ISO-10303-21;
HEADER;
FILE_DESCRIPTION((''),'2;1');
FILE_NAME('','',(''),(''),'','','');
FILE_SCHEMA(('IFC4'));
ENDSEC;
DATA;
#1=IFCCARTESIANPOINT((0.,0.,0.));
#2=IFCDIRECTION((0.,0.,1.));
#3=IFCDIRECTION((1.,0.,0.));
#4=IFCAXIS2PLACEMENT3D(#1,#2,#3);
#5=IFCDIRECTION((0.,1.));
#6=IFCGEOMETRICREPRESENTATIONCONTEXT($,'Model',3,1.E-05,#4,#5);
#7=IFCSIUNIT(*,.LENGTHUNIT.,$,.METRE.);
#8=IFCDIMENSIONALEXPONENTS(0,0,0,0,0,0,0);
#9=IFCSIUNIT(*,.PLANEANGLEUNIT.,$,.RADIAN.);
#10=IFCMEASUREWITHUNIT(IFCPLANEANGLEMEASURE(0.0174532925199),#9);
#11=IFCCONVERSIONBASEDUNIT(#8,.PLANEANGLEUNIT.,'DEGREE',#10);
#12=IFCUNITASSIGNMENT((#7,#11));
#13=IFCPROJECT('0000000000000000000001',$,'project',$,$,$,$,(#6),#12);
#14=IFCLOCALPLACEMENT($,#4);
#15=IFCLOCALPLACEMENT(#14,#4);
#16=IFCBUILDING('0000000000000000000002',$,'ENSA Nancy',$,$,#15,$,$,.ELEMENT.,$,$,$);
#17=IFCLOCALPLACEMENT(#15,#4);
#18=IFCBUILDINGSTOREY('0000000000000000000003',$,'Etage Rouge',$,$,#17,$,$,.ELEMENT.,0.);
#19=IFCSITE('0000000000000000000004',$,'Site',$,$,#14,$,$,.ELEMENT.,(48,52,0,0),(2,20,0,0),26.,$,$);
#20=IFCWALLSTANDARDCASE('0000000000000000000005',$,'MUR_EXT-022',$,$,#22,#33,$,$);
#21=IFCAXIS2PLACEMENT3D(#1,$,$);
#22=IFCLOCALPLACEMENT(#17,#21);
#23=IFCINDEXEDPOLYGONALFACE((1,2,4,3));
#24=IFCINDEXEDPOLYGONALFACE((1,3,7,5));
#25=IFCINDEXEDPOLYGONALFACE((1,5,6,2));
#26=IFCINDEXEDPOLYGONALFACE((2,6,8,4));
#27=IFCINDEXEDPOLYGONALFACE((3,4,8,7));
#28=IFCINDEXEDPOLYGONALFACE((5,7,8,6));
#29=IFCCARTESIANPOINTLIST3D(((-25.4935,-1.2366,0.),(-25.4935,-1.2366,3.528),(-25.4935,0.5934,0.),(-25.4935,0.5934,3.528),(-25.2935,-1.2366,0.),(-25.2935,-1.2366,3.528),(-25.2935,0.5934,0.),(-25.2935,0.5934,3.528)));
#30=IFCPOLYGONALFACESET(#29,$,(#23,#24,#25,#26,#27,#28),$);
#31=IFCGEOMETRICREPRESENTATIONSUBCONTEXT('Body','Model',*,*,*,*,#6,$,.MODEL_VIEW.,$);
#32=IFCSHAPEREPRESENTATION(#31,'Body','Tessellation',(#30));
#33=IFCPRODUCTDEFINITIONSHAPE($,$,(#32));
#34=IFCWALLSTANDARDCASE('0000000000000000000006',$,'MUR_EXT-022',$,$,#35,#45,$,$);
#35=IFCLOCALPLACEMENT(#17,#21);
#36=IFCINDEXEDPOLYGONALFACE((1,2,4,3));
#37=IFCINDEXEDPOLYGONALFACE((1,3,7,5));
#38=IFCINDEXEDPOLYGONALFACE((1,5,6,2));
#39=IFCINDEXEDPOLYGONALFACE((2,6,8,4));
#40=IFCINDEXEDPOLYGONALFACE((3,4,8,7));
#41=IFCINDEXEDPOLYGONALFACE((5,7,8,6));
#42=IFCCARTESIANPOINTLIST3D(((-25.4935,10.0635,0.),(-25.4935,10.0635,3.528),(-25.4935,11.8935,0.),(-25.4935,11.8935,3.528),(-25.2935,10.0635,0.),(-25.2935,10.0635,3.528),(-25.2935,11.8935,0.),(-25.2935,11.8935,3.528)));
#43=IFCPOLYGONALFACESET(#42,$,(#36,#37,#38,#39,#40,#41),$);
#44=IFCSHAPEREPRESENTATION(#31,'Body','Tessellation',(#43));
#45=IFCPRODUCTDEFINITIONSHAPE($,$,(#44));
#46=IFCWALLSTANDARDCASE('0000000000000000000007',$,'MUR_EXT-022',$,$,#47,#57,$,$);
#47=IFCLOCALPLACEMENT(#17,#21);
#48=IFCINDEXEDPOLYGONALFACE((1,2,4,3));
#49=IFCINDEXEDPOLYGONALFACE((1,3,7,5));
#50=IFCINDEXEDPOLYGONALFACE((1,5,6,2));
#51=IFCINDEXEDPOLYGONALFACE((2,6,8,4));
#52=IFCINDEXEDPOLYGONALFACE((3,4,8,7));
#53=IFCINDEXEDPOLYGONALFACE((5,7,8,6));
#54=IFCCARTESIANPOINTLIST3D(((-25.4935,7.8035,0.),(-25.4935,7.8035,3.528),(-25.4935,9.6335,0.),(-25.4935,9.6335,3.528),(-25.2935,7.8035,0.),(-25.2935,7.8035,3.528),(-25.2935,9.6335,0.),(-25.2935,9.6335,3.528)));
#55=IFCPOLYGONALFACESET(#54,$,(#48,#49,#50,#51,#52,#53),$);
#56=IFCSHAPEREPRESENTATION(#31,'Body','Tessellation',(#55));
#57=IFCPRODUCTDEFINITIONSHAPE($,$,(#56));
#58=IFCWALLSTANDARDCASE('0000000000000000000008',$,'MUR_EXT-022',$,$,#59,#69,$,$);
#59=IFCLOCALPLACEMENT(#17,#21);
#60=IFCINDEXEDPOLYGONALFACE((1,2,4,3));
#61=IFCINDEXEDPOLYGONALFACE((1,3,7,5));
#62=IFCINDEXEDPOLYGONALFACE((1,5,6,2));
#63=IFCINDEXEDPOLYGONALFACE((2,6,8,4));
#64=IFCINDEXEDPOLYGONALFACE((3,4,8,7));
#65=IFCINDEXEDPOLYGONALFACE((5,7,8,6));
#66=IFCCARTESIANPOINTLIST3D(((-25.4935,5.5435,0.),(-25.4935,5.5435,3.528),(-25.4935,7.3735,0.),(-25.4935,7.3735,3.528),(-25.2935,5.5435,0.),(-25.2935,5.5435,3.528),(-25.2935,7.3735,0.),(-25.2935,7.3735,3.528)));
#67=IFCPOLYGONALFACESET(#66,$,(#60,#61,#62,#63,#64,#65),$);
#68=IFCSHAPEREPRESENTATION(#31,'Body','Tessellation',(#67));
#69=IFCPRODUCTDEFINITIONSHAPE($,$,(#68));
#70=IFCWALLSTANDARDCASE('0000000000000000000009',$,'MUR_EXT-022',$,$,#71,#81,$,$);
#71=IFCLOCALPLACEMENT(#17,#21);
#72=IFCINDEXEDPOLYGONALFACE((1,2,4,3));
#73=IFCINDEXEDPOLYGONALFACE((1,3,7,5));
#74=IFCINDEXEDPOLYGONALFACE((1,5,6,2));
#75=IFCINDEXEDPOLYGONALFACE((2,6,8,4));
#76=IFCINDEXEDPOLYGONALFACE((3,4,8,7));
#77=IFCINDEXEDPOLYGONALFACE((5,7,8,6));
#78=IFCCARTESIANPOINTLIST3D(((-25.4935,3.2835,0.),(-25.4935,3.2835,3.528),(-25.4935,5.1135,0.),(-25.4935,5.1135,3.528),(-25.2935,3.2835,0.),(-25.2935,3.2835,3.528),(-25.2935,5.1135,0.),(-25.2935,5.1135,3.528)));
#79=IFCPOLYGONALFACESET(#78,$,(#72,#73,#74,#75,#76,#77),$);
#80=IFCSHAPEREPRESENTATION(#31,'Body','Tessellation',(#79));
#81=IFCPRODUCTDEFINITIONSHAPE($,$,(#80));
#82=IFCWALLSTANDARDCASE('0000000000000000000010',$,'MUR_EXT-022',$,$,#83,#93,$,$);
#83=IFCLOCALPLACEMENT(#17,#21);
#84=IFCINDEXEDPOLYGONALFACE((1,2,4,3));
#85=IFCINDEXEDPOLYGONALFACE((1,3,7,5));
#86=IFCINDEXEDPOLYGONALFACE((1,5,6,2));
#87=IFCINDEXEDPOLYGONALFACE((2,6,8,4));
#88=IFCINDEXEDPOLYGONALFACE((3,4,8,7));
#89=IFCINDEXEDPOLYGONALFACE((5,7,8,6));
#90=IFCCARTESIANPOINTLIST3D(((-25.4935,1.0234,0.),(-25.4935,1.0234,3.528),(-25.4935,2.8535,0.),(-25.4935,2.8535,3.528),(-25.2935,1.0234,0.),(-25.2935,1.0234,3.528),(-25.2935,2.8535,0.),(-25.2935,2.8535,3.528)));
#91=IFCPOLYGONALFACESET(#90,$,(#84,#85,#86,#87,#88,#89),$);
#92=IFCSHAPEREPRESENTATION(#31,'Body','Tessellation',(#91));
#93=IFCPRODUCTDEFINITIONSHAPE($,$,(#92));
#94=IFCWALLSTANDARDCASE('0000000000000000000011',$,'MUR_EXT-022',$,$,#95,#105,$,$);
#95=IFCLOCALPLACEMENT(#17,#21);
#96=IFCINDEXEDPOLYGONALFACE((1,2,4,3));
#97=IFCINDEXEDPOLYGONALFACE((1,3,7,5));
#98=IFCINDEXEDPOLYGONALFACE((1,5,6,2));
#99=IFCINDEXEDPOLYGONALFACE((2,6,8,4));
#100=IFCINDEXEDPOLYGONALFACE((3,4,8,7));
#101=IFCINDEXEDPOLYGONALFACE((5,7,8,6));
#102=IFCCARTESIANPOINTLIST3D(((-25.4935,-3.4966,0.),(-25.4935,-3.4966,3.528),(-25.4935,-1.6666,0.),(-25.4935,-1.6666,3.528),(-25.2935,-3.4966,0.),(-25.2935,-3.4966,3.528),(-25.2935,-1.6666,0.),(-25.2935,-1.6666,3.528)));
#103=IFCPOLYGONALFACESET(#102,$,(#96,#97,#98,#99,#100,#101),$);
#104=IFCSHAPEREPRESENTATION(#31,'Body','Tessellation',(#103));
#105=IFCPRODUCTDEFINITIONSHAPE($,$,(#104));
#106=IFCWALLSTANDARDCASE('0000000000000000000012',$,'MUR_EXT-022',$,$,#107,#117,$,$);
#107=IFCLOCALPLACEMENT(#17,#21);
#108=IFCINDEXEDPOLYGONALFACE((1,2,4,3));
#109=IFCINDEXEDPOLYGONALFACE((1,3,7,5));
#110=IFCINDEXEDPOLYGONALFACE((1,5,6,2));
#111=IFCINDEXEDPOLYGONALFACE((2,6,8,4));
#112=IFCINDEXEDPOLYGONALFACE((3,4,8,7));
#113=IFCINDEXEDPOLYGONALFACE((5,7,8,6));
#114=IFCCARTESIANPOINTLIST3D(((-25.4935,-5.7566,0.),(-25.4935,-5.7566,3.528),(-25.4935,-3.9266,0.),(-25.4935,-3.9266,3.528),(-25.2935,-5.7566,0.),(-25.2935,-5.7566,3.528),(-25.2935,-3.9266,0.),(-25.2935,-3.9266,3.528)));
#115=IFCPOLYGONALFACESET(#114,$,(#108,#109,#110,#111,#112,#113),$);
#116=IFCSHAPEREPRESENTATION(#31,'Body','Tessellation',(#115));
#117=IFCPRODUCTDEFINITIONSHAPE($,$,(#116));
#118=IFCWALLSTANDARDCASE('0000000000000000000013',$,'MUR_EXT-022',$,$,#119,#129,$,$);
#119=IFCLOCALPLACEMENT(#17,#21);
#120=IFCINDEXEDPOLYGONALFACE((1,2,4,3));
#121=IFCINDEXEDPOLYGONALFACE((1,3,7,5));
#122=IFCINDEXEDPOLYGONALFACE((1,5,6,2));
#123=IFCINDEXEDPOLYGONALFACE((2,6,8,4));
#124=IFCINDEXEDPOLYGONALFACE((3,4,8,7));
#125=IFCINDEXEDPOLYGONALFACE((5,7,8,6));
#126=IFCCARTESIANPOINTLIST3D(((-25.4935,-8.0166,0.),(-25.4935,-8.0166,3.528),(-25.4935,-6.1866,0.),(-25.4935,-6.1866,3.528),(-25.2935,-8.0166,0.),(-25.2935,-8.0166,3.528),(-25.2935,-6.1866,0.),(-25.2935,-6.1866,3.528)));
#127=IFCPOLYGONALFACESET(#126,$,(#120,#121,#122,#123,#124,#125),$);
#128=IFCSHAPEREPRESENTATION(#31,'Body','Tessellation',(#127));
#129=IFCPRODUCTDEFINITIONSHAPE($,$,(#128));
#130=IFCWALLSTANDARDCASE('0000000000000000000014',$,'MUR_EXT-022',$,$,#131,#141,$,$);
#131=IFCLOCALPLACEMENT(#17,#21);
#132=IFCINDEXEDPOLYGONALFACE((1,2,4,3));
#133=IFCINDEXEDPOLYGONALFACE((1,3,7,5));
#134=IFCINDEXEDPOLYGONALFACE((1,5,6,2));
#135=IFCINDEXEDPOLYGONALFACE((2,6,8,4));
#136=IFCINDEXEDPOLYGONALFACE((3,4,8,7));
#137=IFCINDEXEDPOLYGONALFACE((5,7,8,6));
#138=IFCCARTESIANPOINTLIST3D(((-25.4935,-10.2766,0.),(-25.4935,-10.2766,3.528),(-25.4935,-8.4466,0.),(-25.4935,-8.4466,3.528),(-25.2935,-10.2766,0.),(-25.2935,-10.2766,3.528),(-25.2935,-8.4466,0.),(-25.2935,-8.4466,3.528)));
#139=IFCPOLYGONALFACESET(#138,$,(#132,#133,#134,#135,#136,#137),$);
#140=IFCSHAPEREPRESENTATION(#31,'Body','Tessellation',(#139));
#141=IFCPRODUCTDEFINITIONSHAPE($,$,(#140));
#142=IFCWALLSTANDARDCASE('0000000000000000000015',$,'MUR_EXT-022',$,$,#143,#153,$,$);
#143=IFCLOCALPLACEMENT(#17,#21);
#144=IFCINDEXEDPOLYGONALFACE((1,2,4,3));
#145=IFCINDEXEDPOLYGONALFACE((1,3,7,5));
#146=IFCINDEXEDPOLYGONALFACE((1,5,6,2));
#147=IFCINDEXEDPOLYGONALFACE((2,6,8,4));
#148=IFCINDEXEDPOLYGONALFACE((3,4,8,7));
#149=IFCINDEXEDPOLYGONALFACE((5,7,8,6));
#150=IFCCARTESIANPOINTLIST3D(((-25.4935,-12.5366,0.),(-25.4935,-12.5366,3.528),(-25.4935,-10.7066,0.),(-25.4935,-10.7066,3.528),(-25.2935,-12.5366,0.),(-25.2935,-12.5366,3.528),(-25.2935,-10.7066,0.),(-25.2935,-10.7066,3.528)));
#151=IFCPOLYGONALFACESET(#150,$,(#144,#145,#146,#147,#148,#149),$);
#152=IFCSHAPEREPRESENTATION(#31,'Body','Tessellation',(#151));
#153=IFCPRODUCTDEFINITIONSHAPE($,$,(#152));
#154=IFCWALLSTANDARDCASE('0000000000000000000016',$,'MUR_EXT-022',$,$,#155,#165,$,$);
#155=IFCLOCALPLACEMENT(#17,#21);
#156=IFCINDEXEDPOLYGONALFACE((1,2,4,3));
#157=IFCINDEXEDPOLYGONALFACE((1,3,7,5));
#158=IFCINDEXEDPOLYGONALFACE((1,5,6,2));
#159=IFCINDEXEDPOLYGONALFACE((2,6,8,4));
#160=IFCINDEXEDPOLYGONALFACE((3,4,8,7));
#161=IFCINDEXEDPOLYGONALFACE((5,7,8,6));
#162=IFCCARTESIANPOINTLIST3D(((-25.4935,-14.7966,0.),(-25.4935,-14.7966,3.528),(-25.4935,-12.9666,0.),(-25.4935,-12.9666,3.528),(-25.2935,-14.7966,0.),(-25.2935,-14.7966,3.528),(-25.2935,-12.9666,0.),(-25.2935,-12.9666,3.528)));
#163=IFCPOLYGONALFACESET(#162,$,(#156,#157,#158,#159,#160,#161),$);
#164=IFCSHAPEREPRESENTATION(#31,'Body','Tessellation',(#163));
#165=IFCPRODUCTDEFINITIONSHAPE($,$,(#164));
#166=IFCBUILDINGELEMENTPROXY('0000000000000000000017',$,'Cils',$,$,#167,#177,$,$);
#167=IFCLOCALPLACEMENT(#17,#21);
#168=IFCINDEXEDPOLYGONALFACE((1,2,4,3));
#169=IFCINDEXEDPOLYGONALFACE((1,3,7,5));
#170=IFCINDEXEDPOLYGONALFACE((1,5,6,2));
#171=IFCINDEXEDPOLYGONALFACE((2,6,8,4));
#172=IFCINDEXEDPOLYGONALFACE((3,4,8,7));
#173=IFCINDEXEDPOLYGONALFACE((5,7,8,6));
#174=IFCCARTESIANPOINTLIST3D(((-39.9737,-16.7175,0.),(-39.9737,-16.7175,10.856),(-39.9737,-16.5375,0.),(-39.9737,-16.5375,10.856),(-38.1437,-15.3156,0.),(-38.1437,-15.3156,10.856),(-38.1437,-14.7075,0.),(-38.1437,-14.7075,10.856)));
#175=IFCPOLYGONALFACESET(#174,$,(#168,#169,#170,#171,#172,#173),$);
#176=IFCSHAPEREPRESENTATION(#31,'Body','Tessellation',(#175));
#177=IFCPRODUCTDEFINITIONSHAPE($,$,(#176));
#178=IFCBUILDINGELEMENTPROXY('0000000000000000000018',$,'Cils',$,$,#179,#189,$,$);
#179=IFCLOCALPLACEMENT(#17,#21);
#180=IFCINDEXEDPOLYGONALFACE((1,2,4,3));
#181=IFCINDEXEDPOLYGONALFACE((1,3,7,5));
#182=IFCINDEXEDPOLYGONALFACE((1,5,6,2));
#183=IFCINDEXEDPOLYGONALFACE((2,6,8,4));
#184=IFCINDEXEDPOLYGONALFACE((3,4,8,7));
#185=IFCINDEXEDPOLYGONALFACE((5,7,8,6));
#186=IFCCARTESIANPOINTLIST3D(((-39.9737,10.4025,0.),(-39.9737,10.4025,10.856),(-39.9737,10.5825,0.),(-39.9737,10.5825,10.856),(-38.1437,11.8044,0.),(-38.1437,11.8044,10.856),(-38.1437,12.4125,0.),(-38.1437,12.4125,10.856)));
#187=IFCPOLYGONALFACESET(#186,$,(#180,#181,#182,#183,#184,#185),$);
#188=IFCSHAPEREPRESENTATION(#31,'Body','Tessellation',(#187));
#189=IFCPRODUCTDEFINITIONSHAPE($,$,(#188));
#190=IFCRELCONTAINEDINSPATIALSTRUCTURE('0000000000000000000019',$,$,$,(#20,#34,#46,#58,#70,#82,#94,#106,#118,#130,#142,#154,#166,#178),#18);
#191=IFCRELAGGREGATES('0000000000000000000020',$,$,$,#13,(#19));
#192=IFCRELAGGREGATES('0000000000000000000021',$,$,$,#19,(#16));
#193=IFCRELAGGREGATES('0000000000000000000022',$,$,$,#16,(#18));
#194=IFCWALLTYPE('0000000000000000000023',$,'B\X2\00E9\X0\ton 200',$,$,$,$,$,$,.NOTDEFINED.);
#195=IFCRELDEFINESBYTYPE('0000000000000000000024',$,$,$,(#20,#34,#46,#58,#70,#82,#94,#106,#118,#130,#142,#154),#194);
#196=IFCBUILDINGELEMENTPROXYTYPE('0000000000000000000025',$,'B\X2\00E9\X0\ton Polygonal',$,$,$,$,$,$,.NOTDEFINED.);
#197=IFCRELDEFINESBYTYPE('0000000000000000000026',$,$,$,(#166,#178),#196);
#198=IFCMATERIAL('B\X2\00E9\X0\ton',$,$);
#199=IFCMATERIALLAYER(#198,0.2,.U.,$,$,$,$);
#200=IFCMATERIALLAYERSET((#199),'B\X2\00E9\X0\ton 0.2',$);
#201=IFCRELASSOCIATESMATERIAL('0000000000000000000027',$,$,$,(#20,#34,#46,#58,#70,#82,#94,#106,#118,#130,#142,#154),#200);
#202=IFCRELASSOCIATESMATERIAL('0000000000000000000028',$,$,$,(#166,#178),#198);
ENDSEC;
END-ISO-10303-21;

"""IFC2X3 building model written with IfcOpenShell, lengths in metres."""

from ifc_helpers import new_model, entity, si_unit, converted_unit, direction, frame, origin_with_axes, place, context, subcontext, project, spatial, polyline, outline, extrude, material, layer, layer_set, layer_usage, type_object, element, save


model = new_model("IFC2X3")

# Units and contexts
model_context = context("Model", 3, precision=1e-05, world=origin_with_axes(), true_north=direction((0.0, 1.0)))
body_context = subcontext(model_context, "Body", "Model", "MODEL_VIEW")
ifc_project = project(units=[si_unit("LENGTHUNIT", "METRE"), converted_unit("PLANEANGLEUNIT", "DEGREE", entity("IfcPlaneAngleMeasure", 0.0174532925199), si_unit("PLANEANGLEUNIT", "RADIAN"), dimensions=[0, 0, 0, 0, 0, 0, 0])], contexts=[model_context])

# Site, building, storey
site_placement = place(None, origin_with_axes())
site = spatial("IfcSite", under=ifc_project, at=site_placement, Name="Site", CompositionType="ELEMENT", RefLatitude=(48, 52, 0, 0), RefLongitude=(2, 20, 0, 0), RefElevation=26.0)
building_placement = place(site_placement, origin_with_axes())
building = spatial("IfcBuilding", under=site, at=building_placement, Name="ENSA Nancy", CompositionType="ELEMENT")
storey_placement = place(building_placement, origin_with_axes())
storey = spatial("IfcBuildingStorey", under=building, at=storey_placement, Name="Etage Rouge", CompositionType="ELEMENT", Elevation=0.0)

# Walls
ifc_material = material(Name="Béton")
ifc_layer = layer(ifc_material, 0.2, ventilated="UNKNOWN")
ifc_layer_set = layer_set([ifc_layer], Name="Béton 0.2")
ifc_layer_usage_1 = layer_usage(ifc_layer_set, "AXIS2", "POSITIVE", -0.2)
wall_type = type_object("IfcWallType", Name="Béton 200", PredefinedType="NOTDEFINED")
wall_1_placement = place(storey_placement, frame((-25.2935, 0.5934, 0.0), z_axis=(0.0, 0.0, 1.0), x_axis=(0.0, -1.0, 0.0)))
element("IfcWallStandardCase", 1, at=wall_1_placement, inside=storey, type_object=wall_type, material=ifc_layer_usage_1, Name="MUR_EXT-022", context=body_context, shape_type="SweptSolid", body=[
    extrude(outline(polyline([(0.0, -0.2), (1.83, -0.2), (1.83, 0.0), (0.0, 0.0), (0.0, -0.2)])), origin_with_axes(), (0.0, 0.0, 1.0), 3.528),
])
ifc_layer_usage_2 = layer_usage(ifc_layer_set, "AXIS2", "POSITIVE", -0.2)
wall_2_placement = place(storey_placement, frame((-25.2935, 11.8935, 0.0), z_axis=(0.0, 0.0, 1.0), x_axis=(0.0, -1.0, 0.0)))
element("IfcWallStandardCase", 2, at=wall_2_placement, inside=storey, type_object=wall_type, material=ifc_layer_usage_2, Name="MUR_EXT-022", context=body_context, shape_type="SweptSolid", body=[
    extrude(outline(polyline([(0.0, -0.2), (1.83, -0.2), (1.83, 0.0), (0.0, 0.0), (0.0, -0.2)])), origin_with_axes(), (0.0, 0.0, 1.0), 3.528),
])
ifc_layer_usage_3 = layer_usage(ifc_layer_set, "AXIS2", "POSITIVE", -0.2)
wall_3_placement = place(storey_placement, frame((-25.2935, 9.6335, 0.0), z_axis=(0.0, 0.0, 1.0), x_axis=(0.0, -1.0, 0.0)))
element("IfcWallStandardCase", 3, at=wall_3_placement, inside=storey, type_object=wall_type, material=ifc_layer_usage_3, Name="MUR_EXT-022", context=body_context, shape_type="SweptSolid", body=[
    extrude(outline(polyline([(0.0, -0.2), (1.83, -0.2), (1.83, 0.0), (0.0, 0.0), (0.0, -0.2)])), origin_with_axes(), (0.0, 0.0, 1.0), 3.528),
])
ifc_layer_usage_4 = layer_usage(ifc_layer_set, "AXIS2", "POSITIVE", -0.2)
wall_4_placement = place(storey_placement, frame((-25.2935, 7.3735, 0.0), z_axis=(0.0, 0.0, 1.0), x_axis=(0.0, -1.0, 0.0)))
element("IfcWallStandardCase", 4, at=wall_4_placement, inside=storey, type_object=wall_type, material=ifc_layer_usage_4, Name="MUR_EXT-022", context=body_context, shape_type="SweptSolid", body=[
    extrude(outline(polyline([(0.0, -0.2), (1.83, -0.2), (1.83, 0.0), (0.0, 0.0), (0.0, -0.2)])), origin_with_axes(), (0.0, 0.0, 1.0), 3.528),
])
ifc_layer_usage_5 = layer_usage(ifc_layer_set, "AXIS2", "POSITIVE", -0.2)
wall_5_placement = place(storey_placement, frame((-25.2935, 5.1135, 0.0), z_axis=(0.0, 0.0, 1.0), x_axis=(0.0, -1.0, 0.0)))
element("IfcWallStandardCase", 5, at=wall_5_placement, inside=storey, type_object=wall_type, material=ifc_layer_usage_5, Name="MUR_EXT-022", context=body_context, shape_type="SweptSolid", body=[
    extrude(outline(polyline([(0.0, -0.2), (1.83, -0.2), (1.83, 0.0), (0.0, 0.0), (0.0, -0.2)])), origin_with_axes(), (0.0, 0.0, 1.0), 3.528),
])
ifc_layer_usage_6 = layer_usage(ifc_layer_set, "AXIS2", "POSITIVE", -0.2)
wall_6_placement = place(storey_placement, frame((-25.2935, 2.8535, 0.0), z_axis=(0.0, 0.0, 1.0), x_axis=(0.0, -1.0, 0.0)))
element("IfcWallStandardCase", 6, at=wall_6_placement, inside=storey, type_object=wall_type, material=ifc_layer_usage_6, Name="MUR_EXT-022", context=body_context, shape_type="SweptSolid", body=[
    extrude(outline(polyline([(0.0, -0.2), (1.83, -0.2), (1.83, 0.0), (0.0, 0.0), (0.0, -0.2)])), origin_with_axes(), (0.0, 0.0, 1.0), 3.528),
])
ifc_layer_usage_7 = layer_usage(ifc_layer_set, "AXIS2", "POSITIVE", -0.2)
wall_7_placement = place(storey_placement, frame((-25.2935, -1.6666, 0.0), z_axis=(0.0, 0.0, 1.0), x_axis=(0.0, -1.0, 0.0)))
element("IfcWallStandardCase", 7, at=wall_7_placement, inside=storey, type_object=wall_type, material=ifc_layer_usage_7, Name="MUR_EXT-022", context=body_context, shape_type="SweptSolid", body=[
    extrude(outline(polyline([(0.0, -0.2), (1.83, -0.2), (1.83, 0.0), (0.0, 0.0), (0.0, -0.2)])), origin_with_axes(), (0.0, 0.0, 1.0), 3.528),
])
ifc_layer_usage_8 = layer_usage(ifc_layer_set, "AXIS2", "POSITIVE", -0.2)
wall_8_placement = place(storey_placement, frame((-25.2935, -3.9266, 0.0), z_axis=(0.0, 0.0, 1.0), x_axis=(0.0, -1.0, 0.0)))
element("IfcWallStandardCase", 8, at=wall_8_placement, inside=storey, type_object=wall_type, material=ifc_layer_usage_8, Name="MUR_EXT-022", context=body_context, shape_type="SweptSolid", body=[
    extrude(outline(polyline([(0.0, -0.2), (1.83, -0.2), (1.83, 0.0), (0.0, 0.0), (0.0, -0.2)])), origin_with_axes(), (0.0, 0.0, 1.0), 3.528),
])
ifc_layer_usage_9 = layer_usage(ifc_layer_set, "AXIS2", "POSITIVE", -0.2)
wall_9_placement = place(storey_placement, frame((-25.2935, -6.1866, 0.0), z_axis=(0.0, 0.0, 1.0), x_axis=(0.0, -1.0, 0.0)))
element("IfcWallStandardCase", 9, at=wall_9_placement, inside=storey, type_object=wall_type, material=ifc_layer_usage_9, Name="MUR_EXT-022", context=body_context, shape_type="SweptSolid", body=[
    extrude(outline(polyline([(0.0, -0.2), (1.83, -0.2), (1.83, 0.0), (0.0, 0.0), (0.0, -0.2)])), origin_with_axes(), (0.0, 0.0, 1.0), 3.528),
])
ifc_layer_usage_10 = layer_usage(ifc_layer_set, "AXIS2", "POSITIVE", -0.2)
wall_10_placement = place(storey_placement, frame((-25.2935, -8.4466, 0.0), z_axis=(0.0, 0.0, 1.0), x_axis=(0.0, -1.0, 0.0)))
element("IfcWallStandardCase", 10, at=wall_10_placement, inside=storey, type_object=wall_type, material=ifc_layer_usage_10, Name="MUR_EXT-022", context=body_context, shape_type="SweptSolid", body=[
    extrude(outline(polyline([(0.0, -0.2), (1.83, -0.2), (1.83, 0.0), (0.0, 0.0), (0.0, -0.2)])), origin_with_axes(), (0.0, 0.0, 1.0), 3.528),
])
ifc_layer_usage_11 = layer_usage(ifc_layer_set, "AXIS2", "POSITIVE", -0.2)
wall_11_placement = place(storey_placement, frame((-25.2935, -10.7066, 0.0), z_axis=(0.0, 0.0, 1.0), x_axis=(0.0, -1.0, 0.0)))
element("IfcWallStandardCase", 11, at=wall_11_placement, inside=storey, type_object=wall_type, material=ifc_layer_usage_11, Name="MUR_EXT-022", context=body_context, shape_type="SweptSolid", body=[
    extrude(outline(polyline([(0.0, -0.2), (1.83, -0.2), (1.83, 0.0), (0.0, 0.0), (0.0, -0.2)])), origin_with_axes(), (0.0, 0.0, 1.0), 3.528),
])
ifc_layer_usage_12 = layer_usage(ifc_layer_set, "AXIS2", "POSITIVE", -0.2)
wall_12_placement = place(storey_placement, frame((-25.2935, -12.9666, 0.0), z_axis=(0.0, 0.0, 1.0), x_axis=(0.0, -1.0, 0.0)))
element("IfcWallStandardCase", 12, at=wall_12_placement, inside=storey, type_object=wall_type, material=ifc_layer_usage_12, Name="MUR_EXT-022", context=body_context, shape_type="SweptSolid", body=[
    extrude(outline(polyline([(0.0, -0.2), (1.83, -0.2), (1.83, 0.0), (0.0, 0.0), (0.0, -0.2)])), origin_with_axes(), (0.0, 0.0, 1.0), 3.528),
])

# Building element proxies
building_element_proxy_type = type_object("IfcBuildingElementProxyType", Name="Béton Polygonal", PredefinedType="NOTDEFINED")
for number, where, z_axis, x_axis, name in (
    (13, (-38.1437, -14.7075, 0.0), (0.0, 0.0, 1.0), (-0.707107, -0.707107, 0.0), "Cils"),
    (14, (-38.1437, 12.4125, 0.0), (0.0, 0.0, 1.0), (-0.707107, -0.707107, 0.0), "Cils"),
):
    element("IfcBuildingElementProxy", number, at=place(storey_placement, frame(where, z_axis=z_axis, x_axis=x_axis)), inside=storey, type_object=building_element_proxy_type, material=ifc_material, Name=name, context=body_context, shape_type="SweptSolid", body=[
        extrude(outline(polyline([(0.0, 0.0), (2.588, 0.0), (2.7153, 0.1273), (0.43, 0.43), (0.0, 0.0)])), origin_with_axes(), (0.0, 0.0, 1.0), 10.856),
    ])

save(model, "model.ifc")
